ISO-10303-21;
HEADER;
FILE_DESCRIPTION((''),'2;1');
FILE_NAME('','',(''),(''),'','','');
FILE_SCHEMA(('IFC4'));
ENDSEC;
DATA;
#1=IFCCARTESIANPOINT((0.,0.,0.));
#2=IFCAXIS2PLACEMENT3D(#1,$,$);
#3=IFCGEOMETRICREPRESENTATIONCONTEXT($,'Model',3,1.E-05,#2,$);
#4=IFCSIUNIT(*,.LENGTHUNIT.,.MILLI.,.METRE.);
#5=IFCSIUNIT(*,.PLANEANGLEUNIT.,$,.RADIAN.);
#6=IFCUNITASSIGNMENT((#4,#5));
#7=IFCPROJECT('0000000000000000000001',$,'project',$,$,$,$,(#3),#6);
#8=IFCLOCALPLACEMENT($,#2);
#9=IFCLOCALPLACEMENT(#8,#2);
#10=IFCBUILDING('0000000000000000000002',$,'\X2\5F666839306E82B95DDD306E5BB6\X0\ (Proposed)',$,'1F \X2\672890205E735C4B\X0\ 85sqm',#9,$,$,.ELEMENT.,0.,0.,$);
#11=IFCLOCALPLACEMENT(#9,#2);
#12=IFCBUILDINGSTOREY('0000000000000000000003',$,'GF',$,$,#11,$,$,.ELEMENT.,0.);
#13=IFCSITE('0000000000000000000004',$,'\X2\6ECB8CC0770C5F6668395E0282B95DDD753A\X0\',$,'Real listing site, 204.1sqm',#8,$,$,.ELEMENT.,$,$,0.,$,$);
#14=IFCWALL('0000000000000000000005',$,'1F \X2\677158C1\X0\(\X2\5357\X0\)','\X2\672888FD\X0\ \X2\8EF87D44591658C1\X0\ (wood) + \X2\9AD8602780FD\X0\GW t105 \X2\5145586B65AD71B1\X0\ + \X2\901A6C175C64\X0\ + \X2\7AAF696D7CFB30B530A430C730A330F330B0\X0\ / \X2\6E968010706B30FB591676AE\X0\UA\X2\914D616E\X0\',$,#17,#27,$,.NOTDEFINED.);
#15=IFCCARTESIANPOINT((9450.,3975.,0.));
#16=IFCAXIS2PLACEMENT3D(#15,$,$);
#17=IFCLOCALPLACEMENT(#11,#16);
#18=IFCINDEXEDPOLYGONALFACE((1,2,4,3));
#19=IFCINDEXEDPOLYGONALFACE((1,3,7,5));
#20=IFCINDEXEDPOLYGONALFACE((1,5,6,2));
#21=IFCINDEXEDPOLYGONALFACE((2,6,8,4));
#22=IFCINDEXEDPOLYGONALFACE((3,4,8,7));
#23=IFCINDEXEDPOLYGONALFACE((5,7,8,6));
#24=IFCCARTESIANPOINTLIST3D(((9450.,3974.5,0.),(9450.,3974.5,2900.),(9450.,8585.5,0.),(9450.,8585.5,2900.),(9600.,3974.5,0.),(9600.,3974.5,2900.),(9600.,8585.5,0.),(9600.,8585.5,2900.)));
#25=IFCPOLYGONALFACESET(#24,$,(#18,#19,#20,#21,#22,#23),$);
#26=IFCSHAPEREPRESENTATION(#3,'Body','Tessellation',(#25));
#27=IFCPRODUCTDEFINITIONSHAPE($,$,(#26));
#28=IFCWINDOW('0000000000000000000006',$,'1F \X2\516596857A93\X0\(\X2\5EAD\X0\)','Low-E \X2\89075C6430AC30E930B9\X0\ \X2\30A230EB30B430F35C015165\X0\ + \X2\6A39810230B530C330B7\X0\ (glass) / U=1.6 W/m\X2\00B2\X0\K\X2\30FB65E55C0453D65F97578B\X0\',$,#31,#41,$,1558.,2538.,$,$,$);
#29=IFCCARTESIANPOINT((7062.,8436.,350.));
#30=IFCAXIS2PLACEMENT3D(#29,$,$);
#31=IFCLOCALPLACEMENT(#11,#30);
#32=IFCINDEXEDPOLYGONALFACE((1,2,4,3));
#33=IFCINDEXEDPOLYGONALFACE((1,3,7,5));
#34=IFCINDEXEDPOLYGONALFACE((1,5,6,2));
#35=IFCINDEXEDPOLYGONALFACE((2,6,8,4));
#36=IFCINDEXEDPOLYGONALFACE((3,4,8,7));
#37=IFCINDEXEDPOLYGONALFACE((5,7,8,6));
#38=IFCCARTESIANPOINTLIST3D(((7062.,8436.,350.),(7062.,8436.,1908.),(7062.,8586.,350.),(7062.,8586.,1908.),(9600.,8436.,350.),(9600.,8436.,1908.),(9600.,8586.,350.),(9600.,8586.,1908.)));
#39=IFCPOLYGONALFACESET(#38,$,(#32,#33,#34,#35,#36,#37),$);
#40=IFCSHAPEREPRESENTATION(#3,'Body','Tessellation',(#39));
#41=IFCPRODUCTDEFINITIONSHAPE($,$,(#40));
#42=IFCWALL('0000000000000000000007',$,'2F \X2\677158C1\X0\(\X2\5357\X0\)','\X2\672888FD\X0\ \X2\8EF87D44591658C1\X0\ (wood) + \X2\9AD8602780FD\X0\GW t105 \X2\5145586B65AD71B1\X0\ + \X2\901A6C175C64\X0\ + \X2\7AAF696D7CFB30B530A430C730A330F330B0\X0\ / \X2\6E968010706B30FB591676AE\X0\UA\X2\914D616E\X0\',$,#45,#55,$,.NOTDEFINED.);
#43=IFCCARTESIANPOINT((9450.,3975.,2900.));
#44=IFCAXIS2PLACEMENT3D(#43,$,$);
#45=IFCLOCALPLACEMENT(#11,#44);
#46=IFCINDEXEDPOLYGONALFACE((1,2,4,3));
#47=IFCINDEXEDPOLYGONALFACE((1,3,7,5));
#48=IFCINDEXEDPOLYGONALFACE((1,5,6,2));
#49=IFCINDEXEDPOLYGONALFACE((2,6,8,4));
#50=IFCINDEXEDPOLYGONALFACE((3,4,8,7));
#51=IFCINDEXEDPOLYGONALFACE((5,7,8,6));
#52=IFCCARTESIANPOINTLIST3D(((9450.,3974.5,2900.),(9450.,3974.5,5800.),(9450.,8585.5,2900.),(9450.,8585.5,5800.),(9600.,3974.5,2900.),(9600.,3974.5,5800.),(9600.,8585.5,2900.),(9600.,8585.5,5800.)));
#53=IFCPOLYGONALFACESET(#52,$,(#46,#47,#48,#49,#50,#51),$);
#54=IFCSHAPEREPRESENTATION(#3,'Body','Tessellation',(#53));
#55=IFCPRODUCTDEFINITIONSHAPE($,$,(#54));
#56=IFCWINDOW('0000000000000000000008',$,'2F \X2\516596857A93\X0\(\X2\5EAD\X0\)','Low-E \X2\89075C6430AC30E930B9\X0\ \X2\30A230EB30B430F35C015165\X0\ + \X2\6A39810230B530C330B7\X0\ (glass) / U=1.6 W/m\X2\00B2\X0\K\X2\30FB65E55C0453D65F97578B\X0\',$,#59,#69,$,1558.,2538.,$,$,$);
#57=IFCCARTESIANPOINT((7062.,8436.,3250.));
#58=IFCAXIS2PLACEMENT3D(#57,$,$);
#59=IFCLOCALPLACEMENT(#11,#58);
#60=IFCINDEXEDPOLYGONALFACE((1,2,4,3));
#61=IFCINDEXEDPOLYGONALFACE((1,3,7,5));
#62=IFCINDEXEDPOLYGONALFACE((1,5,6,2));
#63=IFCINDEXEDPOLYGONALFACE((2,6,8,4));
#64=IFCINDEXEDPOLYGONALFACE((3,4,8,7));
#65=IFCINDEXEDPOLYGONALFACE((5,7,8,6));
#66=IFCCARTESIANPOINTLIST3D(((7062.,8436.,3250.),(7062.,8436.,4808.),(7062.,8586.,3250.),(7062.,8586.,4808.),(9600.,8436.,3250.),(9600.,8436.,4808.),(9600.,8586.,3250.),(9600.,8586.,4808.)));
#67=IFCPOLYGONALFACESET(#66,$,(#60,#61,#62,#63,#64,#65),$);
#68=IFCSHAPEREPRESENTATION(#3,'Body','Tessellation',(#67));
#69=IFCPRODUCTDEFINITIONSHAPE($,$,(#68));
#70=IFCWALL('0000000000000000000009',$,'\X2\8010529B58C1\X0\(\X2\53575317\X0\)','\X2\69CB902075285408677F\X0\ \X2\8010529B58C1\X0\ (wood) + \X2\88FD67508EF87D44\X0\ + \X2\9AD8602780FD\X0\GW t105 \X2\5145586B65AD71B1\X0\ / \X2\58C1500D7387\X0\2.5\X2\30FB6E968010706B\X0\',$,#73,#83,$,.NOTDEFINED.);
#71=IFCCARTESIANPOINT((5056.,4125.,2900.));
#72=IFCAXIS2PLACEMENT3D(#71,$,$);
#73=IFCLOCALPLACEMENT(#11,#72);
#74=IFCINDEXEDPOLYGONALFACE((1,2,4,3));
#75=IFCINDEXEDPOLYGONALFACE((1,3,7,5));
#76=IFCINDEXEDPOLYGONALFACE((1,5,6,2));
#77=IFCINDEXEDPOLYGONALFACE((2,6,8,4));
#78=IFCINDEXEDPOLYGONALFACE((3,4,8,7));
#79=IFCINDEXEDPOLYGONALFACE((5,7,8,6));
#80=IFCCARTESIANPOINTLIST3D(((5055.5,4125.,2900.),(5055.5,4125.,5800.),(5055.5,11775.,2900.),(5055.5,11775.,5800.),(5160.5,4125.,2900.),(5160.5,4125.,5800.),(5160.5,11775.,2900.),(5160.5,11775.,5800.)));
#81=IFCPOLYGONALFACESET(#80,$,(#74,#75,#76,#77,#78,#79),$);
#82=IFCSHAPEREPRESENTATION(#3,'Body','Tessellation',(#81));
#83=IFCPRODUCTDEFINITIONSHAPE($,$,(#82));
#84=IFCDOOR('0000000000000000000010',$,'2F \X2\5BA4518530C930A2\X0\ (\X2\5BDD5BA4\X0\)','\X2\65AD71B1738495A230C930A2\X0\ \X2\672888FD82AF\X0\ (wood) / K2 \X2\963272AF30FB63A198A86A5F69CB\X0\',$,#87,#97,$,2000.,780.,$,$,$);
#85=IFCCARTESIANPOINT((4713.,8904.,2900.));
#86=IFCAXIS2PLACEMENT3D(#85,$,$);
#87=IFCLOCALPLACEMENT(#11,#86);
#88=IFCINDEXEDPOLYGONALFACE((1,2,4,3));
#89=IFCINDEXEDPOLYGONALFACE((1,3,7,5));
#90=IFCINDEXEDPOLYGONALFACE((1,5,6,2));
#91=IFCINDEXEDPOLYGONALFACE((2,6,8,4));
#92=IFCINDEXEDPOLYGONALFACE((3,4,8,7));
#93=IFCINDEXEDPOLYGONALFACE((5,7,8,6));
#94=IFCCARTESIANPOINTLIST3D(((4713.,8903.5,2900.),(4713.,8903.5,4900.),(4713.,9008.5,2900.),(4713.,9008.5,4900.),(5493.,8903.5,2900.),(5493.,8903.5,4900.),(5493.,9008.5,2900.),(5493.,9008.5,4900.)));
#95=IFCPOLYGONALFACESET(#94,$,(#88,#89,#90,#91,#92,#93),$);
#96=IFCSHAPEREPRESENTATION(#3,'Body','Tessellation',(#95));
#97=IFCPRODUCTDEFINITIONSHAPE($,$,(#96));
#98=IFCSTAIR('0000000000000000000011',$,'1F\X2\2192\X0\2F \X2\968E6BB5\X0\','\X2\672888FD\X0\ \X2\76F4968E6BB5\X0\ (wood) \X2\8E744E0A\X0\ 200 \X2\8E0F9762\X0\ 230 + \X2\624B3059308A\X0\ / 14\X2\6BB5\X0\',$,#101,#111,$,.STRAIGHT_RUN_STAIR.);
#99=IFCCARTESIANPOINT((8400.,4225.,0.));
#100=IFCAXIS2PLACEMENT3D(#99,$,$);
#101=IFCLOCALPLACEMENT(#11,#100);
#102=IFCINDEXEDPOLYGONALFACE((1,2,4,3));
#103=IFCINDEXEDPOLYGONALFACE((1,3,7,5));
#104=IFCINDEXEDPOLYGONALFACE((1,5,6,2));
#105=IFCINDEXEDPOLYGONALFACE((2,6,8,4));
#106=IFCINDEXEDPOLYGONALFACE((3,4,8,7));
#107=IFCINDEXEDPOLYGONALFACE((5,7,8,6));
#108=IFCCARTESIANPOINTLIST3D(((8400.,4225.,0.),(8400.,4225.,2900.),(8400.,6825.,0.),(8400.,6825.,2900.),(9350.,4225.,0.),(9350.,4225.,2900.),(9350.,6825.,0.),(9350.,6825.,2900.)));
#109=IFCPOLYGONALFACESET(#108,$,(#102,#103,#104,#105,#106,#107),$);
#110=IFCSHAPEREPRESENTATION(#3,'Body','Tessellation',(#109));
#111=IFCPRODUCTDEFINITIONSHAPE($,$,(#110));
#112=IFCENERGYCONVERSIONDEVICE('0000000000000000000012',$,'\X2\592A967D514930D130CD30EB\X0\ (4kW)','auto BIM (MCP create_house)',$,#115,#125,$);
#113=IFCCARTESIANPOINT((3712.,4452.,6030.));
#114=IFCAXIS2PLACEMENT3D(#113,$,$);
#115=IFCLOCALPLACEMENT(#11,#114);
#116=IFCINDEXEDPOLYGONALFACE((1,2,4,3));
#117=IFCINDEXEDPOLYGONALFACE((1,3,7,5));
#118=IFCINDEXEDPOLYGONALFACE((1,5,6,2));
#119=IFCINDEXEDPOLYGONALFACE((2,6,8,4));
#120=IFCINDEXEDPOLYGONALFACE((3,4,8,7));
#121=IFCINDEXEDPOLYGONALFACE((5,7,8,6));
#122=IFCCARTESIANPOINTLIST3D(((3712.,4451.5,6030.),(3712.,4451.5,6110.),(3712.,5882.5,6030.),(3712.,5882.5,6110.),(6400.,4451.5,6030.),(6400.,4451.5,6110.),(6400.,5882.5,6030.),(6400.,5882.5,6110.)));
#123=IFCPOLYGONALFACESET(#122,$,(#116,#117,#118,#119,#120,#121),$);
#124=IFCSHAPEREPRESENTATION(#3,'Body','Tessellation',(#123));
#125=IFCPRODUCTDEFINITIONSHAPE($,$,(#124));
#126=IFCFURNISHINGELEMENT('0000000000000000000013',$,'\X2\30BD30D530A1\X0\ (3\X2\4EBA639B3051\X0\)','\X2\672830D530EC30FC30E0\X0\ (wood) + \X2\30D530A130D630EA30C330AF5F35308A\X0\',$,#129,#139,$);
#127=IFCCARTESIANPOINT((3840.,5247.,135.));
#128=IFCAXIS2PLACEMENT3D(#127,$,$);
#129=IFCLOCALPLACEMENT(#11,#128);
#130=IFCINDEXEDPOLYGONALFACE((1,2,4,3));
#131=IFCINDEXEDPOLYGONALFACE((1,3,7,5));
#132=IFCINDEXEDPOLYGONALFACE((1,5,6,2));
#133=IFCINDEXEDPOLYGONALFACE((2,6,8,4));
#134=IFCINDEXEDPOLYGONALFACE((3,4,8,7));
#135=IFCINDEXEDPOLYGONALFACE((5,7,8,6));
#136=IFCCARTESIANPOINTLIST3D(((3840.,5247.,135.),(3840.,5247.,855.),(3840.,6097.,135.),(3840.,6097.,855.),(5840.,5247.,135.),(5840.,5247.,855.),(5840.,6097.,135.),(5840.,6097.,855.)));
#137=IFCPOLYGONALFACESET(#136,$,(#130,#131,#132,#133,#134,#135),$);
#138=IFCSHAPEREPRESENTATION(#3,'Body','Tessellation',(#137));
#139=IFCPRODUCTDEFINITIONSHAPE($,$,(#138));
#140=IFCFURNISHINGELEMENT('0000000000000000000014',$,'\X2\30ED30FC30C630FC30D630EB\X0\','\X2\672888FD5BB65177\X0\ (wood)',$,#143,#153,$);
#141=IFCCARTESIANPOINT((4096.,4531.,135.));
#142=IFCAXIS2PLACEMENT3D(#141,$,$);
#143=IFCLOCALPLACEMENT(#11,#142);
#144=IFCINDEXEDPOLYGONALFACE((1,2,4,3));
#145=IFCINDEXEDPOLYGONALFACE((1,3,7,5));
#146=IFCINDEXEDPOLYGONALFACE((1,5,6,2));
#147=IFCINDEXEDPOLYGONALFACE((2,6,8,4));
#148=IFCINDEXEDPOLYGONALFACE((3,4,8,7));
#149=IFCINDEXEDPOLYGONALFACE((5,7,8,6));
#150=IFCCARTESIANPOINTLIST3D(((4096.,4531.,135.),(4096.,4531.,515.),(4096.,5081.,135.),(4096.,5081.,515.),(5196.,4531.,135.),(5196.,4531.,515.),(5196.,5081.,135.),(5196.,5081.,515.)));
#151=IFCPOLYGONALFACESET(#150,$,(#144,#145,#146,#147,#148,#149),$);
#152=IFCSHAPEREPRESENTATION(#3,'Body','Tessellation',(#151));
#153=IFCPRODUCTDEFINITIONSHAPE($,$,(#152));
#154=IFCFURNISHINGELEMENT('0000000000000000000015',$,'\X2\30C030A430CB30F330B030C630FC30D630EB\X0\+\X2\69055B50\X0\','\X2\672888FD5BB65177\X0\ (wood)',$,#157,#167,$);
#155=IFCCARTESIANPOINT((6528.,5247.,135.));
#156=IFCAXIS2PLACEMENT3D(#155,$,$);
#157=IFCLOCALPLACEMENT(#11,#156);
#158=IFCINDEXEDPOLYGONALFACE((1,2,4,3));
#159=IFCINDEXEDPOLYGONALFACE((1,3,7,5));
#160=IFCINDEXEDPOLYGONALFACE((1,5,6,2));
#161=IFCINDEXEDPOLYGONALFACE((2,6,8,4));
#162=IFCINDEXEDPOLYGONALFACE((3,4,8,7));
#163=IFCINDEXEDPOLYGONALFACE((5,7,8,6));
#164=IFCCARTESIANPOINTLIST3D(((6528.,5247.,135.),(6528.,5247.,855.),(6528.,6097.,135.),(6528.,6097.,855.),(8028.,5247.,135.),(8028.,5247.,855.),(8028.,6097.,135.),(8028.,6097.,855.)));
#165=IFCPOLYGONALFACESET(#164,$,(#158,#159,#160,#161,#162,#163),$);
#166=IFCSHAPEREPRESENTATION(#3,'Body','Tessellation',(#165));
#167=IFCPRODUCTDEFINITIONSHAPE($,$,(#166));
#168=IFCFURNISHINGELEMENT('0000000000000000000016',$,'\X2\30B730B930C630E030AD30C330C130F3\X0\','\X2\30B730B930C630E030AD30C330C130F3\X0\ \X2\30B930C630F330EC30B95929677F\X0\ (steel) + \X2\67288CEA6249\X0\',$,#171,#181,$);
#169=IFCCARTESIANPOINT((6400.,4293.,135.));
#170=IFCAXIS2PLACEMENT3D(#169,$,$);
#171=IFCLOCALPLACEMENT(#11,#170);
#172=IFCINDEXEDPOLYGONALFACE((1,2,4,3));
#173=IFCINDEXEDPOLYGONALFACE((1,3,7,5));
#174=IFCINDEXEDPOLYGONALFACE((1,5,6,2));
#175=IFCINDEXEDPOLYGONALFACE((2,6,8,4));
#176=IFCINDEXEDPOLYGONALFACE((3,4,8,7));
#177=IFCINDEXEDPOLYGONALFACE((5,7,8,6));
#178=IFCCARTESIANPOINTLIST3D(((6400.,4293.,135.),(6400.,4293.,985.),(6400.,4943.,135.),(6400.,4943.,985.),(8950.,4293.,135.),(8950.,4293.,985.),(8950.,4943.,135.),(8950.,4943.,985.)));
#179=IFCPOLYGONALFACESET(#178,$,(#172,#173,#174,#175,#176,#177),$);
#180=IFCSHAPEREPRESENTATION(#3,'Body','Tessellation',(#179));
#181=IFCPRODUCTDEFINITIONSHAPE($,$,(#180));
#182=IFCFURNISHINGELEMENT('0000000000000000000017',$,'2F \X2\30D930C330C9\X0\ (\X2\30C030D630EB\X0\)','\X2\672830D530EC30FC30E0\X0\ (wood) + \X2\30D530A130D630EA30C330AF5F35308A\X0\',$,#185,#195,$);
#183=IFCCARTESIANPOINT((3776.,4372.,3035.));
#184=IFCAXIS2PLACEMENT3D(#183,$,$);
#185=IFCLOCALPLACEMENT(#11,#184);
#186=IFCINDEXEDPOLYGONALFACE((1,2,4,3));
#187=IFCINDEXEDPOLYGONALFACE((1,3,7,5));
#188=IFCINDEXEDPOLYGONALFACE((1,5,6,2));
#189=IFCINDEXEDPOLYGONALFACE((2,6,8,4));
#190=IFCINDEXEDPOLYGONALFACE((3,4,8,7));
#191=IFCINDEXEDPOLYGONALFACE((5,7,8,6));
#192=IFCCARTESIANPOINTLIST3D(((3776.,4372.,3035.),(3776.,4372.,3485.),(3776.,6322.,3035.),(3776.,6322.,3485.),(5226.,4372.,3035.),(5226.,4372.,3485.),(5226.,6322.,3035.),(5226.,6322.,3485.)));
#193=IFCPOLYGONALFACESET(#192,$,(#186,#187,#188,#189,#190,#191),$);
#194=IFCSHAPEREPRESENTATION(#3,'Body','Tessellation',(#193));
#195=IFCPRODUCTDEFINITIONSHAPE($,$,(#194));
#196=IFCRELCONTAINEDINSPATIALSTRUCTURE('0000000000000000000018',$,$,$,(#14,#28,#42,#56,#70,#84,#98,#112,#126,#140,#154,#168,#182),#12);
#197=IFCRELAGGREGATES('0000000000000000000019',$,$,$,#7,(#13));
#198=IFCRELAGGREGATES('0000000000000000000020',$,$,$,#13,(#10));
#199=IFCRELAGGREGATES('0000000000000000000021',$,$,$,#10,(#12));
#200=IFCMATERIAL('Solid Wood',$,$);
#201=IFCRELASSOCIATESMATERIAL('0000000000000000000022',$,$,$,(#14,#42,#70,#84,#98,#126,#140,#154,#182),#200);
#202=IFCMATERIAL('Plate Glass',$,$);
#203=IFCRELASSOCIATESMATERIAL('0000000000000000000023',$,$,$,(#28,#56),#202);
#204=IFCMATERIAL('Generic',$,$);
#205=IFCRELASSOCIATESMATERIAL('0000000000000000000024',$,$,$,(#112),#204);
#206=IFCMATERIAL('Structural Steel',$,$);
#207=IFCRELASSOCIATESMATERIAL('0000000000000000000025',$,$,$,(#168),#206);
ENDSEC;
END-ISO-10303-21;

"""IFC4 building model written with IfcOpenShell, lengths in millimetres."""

from ifc_helpers import new_model, si_unit, frame, frame_2d, origin, place, context, project, spatial, rectangle, extrude, material, element, fill, save


model = new_model("IFC4")

# Units and contexts
model_context = context("Model", 3, precision=1e-05, world=origin())
ifc_project = project(units=[si_unit("LENGTHUNIT", "METRE", prefix="MILLI"), si_unit("PLANEANGLEUNIT", "RADIAN")], contexts=[model_context])

# Site, building, storey
site_placement = place(None, origin())
site = spatial("IfcSite", under=ifc_project, at=site_placement, Name="滋賀県彦根市芹川町", ObjectType="Real listing site, 204.1sqm", CompositionType="ELEMENT", RefElevation=0.0)
building_placement = place(site_placement, origin())
building = spatial("IfcBuilding", under=site, at=building_placement, Name="彦根の芹川の家 (Proposed)", ObjectType="1F 木造平屋 85sqm", CompositionType="ELEMENT", ElevationOfRefHeight=0.0, ElevationOfTerrain=0.0)
storey_placement = place(building_placement, origin())
storey = spatial("IfcBuildingStorey", under=building, at=storey_placement, Name="GF", CompositionType="ELEMENT", Elevation=0.0)

# Wall, opening, window
ifc_material_1 = material(Name="Solid Wood")
wall_1_placement = place(storey_placement, frame((9450.0, 3975.0, 0.0)))
wall_1 = element("IfcWall", 1, at=wall_1_placement, inside=storey, material=ifc_material_1, Name="1F 東壁(南)", Description="木製 軸組外壁 (wood) + 高性能GW t105 充填断熱 + 通気層 + 窯業系サイディング / 準耐火・外皮UA配慮", PredefinedType="NOTDEFINED", context=model_context, shape_type="SweptSolid", body=[
    extrude(rectangle(XDim=150.0, YDim=4611.0, at=frame_2d((75.0, 2305.0))), frame((9450.0, 3975.0, 0.0)), (0.0, 0.0, 1.0), 2900.0),
])
opening_1_placement = place(storey_placement, frame((7062.0, 8436.0, 350.0)))
opening_1 = element("IfcOpeningElement", 2, at=opening_1_placement, cuts=wall_1, PredefinedType="NOTDEFINED", context=model_context, shape_type="SweptSolid", body=[
    extrude(rectangle(XDim=2538.0, YDim=150.0, at=frame_2d((1269.0, 75.0))), frame((7062.0, 8436.0, 350.0)), (0.0, 0.0, 1.0), 1558.0),
])
ifc_material_2 = material(Name="Plate Glass")
window_1_placement = place(storey_placement, frame((7062.0, 8436.0, 350.0)))
window_1 = element("IfcWindow", 3, at=window_1_placement, inside=storey, material=ifc_material_2, Name="1F 入隅窓(庭)", Description="Low-E 複層ガラス アルゴン封入 + 樹脂サッシ (glass) / U=1.6 W/m²K・日射取得型", OverallHeight=1558.0, OverallWidth=2538.0, context=model_context, shape_type="SweptSolid", body=[
    extrude(rectangle(XDim=2538.0, YDim=150.0, at=frame_2d((1269.0, 75.0))), frame((7062.0, 8436.0, 350.0)), (0.0, 0.0, 1.0), 1558.0),
])
fill(opening_1, window_1)

# Wall, opening, window
wall_2_placement = place(storey_placement, frame((9450.0, 3975.0, 2900.0)))
wall_2 = element("IfcWall", 4, at=wall_2_placement, inside=storey, material=ifc_material_1, Name="2F 東壁(南)", Description="木製 軸組外壁 (wood) + 高性能GW t105 充填断熱 + 通気層 + 窯業系サイディング / 準耐火・外皮UA配慮", PredefinedType="NOTDEFINED", context=model_context, shape_type="SweptSolid", body=[
    extrude(rectangle(XDim=150.0, YDim=4611.0, at=frame_2d((75.0, 2305.0))), frame((9450.0, 3975.0, 2900.0)), (0.0, 0.0, 1.0), 2900.0),
])
opening_2_placement = place(storey_placement, frame((7062.0, 8436.0, 3250.0)))
opening_2 = element("IfcOpeningElement", 5, at=opening_2_placement, cuts=wall_2, PredefinedType="NOTDEFINED", context=model_context, shape_type="SweptSolid", body=[
    extrude(rectangle(XDim=2538.0, YDim=150.0, at=frame_2d((1269.0, 75.0))), frame((7062.0, 8436.0, 3250.0)), (0.0, 0.0, 1.0), 1558.0),
])
window_2_placement = place(storey_placement, frame((7062.0, 8436.0, 3250.0)))
window_2 = element("IfcWindow", 6, at=window_2_placement, inside=storey, material=ifc_material_2, Name="2F 入隅窓(庭)", Description="Low-E 複層ガラス アルゴン封入 + 樹脂サッシ (glass) / U=1.6 W/m²K・日射取得型", OverallHeight=1558.0, OverallWidth=2538.0, context=model_context, shape_type="SweptSolid", body=[
    extrude(rectangle(XDim=2538.0, YDim=150.0, at=frame_2d((1269.0, 75.0))), frame((7062.0, 8436.0, 3250.0)), (0.0, 0.0, 1.0), 1558.0),
])
fill(opening_2, window_2)

# Wall, opening, door
wall_3_placement = place(storey_placement, frame((5056.0, 4125.0, 2900.0)))
wall_3 = element("IfcWall", 7, at=wall_3_placement, inside=storey, material=ifc_material_1, Name="耐力壁(南北)", Description="構造用合板 耐力壁 (wood) + 製材軸組 + 高性能GW t105 充填断熱 / 壁倍率2.5・準耐火", PredefinedType="NOTDEFINED", context=model_context, shape_type="SweptSolid", body=[
    extrude(rectangle(XDim=105.0, YDim=7650.0, at=frame_2d((52.0, 3825.0))), frame((5056.0, 4125.0, 2900.0)), (0.0, 0.0, 1.0), 2900.0),
])
opening_3_placement = place(storey_placement, frame((4713.0, 8904.0, 2900.0)))
opening_3 = element("IfcOpeningElement", 8, at=opening_3_placement, cuts=wall_3, PredefinedType="NOTDEFINED", context=model_context, shape_type="SweptSolid", body=[
    extrude(rectangle(XDim=780.0, YDim=105.0, at=frame_2d((390.0, 52.0))), frame((4713.0, 8904.0, 2900.0)), (0.0, 0.0, 1.0), 2000.0),
])
door_1_placement = place(storey_placement, frame((4713.0, 8904.0, 2900.0)))
door_1 = element("IfcDoor", 9, at=door_1_placement, inside=storey, material=ifc_material_1, Name="2F 室内ドア (寝室)", Description="断熱玄関ドア 木製芯 (wood) / K2 防犯・採風機構", OverallHeight=2000.0, OverallWidth=780.0, context=model_context, shape_type="SweptSolid", body=[
    extrude(rectangle(XDim=780.0, YDim=105.0, at=frame_2d((390.0, 52.0))), frame((4713.0, 8904.0, 2900.0)), (0.0, 0.0, 1.0), 2000.0),
])
fill(opening_3, door_1)

# Stair
stair_placement = place(storey_placement, frame((8400.0, 4225.0, 0.0)))
element("IfcStair", 10, at=stair_placement, inside=storey, material=ifc_material_1, Name="1F→2F 階段", Description="木製 直階段 (wood) 蹴上 200 踏面 230 + 手すり / 14段", PredefinedType="STRAIGHT_RUN_STAIR", context=model_context, shape_type="SweptSolid", body=[
    extrude(rectangle(XDim=950.0, YDim=2600.0, at=frame_2d((475.0, 1300.0))), frame((8400.0, 4225.0, 0.0)), (0.0, 0.0, 1.0), 2900.0),
])

# Energy conversion device
ifc_material_3 = material(Name="Generic")
energy_conversion_device_placement = place(storey_placement, frame((3712.0, 4452.0, 6030.0)))
element("IfcEnergyConversionDevice", 11, at=energy_conversion_device_placement, inside=storey, material=ifc_material_3, Name="太陽光パネル (4kW)", Description="auto BIM (MCP create_house)", context=model_context, shape_type="SweptSolid", body=[
    extrude(rectangle(XDim=2688.0, YDim=1431.0, at=frame_2d((1344.0, 715.0))), frame((3712.0, 4452.0, 6030.0)), (0.0, 0.0, 1.0), 80.0),
])

# Furnishing elements
furnishing_1_placement = place(storey_placement, frame((3840.0, 5247.0, 135.0)))
element("IfcFurnishingElement", 12, at=furnishing_1_placement, inside=storey, material=ifc_material_1, Name="ソファ (3人掛け)", Description="木フレーム (wood) + ファブリック張り", context=model_context, shape_type="SweptSolid", body=[
    extrude(rectangle(XDim=2000.0, YDim=850.0, at=frame_2d((1000.0, 425.0))), frame((3840.0, 5247.0, 135.0)), (0.0, 0.0, 1.0), 720.0),
])
furnishing_2_placement = place(storey_placement, frame((4096.0, 4531.0, 135.0)))
element("IfcFurnishingElement", 13, at=furnishing_2_placement, inside=storey, material=ifc_material_1, Name="ローテーブル", Description="木製家具 (wood)", context=model_context, shape_type="SweptSolid", body=[
    extrude(rectangle(XDim=1100.0, YDim=550.0, at=frame_2d((550.0, 275.0))), frame((4096.0, 4531.0, 135.0)), (0.0, 0.0, 1.0), 380.0),
])
furnishing_3_placement = place(storey_placement, frame((6528.0, 5247.0, 135.0)))
element("IfcFurnishingElement", 14, at=furnishing_3_placement, inside=storey, material=ifc_material_1, Name="ダイニングテーブル+椅子", Description="木製家具 (wood)", context=model_context, shape_type="SweptSolid", body=[
    extrude(rectangle(XDim=1500.0, YDim=850.0, at=frame_2d((750.0, 425.0))), frame((6528.0, 5247.0, 135.0)), (0.0, 0.0, 1.0), 720.0),
])
ifc_material_4 = material(Name="Structural Steel")
furnishing_4_placement = place(storey_placement, frame((6400.0, 4293.0, 135.0)))
element("IfcFurnishingElement", 15, at=furnishing_4_placement, inside=storey, material=ifc_material_4, Name="システムキッチン", Description="システムキッチン ステンレス天板 (steel) + 木質扉", context=model_context, shape_type="SweptSolid", body=[
    extrude(rectangle(XDim=2550.0, YDim=650.0, at=frame_2d((1275.0, 325.0))), frame((6400.0, 4293.0, 135.0)), (0.0, 0.0, 1.0), 850.0),
])
furnishing_5_placement = place(storey_placement, frame((3776.0, 4372.0, 3035.0)))
element("IfcFurnishingElement", 16, at=furnishing_5_placement, inside=storey, material=ifc_material_1, Name="2F ベッド (ダブル)", Description="木フレーム (wood) + ファブリック張り", context=model_context, shape_type="SweptSolid", body=[
    extrude(rectangle(XDim=1450.0, YDim=1950.0, at=frame_2d((725.0, 975.0))), frame((3776.0, 4372.0, 3035.0)), (0.0, 0.0, 1.0), 450.0),
])

save(model, "model.ifc")
